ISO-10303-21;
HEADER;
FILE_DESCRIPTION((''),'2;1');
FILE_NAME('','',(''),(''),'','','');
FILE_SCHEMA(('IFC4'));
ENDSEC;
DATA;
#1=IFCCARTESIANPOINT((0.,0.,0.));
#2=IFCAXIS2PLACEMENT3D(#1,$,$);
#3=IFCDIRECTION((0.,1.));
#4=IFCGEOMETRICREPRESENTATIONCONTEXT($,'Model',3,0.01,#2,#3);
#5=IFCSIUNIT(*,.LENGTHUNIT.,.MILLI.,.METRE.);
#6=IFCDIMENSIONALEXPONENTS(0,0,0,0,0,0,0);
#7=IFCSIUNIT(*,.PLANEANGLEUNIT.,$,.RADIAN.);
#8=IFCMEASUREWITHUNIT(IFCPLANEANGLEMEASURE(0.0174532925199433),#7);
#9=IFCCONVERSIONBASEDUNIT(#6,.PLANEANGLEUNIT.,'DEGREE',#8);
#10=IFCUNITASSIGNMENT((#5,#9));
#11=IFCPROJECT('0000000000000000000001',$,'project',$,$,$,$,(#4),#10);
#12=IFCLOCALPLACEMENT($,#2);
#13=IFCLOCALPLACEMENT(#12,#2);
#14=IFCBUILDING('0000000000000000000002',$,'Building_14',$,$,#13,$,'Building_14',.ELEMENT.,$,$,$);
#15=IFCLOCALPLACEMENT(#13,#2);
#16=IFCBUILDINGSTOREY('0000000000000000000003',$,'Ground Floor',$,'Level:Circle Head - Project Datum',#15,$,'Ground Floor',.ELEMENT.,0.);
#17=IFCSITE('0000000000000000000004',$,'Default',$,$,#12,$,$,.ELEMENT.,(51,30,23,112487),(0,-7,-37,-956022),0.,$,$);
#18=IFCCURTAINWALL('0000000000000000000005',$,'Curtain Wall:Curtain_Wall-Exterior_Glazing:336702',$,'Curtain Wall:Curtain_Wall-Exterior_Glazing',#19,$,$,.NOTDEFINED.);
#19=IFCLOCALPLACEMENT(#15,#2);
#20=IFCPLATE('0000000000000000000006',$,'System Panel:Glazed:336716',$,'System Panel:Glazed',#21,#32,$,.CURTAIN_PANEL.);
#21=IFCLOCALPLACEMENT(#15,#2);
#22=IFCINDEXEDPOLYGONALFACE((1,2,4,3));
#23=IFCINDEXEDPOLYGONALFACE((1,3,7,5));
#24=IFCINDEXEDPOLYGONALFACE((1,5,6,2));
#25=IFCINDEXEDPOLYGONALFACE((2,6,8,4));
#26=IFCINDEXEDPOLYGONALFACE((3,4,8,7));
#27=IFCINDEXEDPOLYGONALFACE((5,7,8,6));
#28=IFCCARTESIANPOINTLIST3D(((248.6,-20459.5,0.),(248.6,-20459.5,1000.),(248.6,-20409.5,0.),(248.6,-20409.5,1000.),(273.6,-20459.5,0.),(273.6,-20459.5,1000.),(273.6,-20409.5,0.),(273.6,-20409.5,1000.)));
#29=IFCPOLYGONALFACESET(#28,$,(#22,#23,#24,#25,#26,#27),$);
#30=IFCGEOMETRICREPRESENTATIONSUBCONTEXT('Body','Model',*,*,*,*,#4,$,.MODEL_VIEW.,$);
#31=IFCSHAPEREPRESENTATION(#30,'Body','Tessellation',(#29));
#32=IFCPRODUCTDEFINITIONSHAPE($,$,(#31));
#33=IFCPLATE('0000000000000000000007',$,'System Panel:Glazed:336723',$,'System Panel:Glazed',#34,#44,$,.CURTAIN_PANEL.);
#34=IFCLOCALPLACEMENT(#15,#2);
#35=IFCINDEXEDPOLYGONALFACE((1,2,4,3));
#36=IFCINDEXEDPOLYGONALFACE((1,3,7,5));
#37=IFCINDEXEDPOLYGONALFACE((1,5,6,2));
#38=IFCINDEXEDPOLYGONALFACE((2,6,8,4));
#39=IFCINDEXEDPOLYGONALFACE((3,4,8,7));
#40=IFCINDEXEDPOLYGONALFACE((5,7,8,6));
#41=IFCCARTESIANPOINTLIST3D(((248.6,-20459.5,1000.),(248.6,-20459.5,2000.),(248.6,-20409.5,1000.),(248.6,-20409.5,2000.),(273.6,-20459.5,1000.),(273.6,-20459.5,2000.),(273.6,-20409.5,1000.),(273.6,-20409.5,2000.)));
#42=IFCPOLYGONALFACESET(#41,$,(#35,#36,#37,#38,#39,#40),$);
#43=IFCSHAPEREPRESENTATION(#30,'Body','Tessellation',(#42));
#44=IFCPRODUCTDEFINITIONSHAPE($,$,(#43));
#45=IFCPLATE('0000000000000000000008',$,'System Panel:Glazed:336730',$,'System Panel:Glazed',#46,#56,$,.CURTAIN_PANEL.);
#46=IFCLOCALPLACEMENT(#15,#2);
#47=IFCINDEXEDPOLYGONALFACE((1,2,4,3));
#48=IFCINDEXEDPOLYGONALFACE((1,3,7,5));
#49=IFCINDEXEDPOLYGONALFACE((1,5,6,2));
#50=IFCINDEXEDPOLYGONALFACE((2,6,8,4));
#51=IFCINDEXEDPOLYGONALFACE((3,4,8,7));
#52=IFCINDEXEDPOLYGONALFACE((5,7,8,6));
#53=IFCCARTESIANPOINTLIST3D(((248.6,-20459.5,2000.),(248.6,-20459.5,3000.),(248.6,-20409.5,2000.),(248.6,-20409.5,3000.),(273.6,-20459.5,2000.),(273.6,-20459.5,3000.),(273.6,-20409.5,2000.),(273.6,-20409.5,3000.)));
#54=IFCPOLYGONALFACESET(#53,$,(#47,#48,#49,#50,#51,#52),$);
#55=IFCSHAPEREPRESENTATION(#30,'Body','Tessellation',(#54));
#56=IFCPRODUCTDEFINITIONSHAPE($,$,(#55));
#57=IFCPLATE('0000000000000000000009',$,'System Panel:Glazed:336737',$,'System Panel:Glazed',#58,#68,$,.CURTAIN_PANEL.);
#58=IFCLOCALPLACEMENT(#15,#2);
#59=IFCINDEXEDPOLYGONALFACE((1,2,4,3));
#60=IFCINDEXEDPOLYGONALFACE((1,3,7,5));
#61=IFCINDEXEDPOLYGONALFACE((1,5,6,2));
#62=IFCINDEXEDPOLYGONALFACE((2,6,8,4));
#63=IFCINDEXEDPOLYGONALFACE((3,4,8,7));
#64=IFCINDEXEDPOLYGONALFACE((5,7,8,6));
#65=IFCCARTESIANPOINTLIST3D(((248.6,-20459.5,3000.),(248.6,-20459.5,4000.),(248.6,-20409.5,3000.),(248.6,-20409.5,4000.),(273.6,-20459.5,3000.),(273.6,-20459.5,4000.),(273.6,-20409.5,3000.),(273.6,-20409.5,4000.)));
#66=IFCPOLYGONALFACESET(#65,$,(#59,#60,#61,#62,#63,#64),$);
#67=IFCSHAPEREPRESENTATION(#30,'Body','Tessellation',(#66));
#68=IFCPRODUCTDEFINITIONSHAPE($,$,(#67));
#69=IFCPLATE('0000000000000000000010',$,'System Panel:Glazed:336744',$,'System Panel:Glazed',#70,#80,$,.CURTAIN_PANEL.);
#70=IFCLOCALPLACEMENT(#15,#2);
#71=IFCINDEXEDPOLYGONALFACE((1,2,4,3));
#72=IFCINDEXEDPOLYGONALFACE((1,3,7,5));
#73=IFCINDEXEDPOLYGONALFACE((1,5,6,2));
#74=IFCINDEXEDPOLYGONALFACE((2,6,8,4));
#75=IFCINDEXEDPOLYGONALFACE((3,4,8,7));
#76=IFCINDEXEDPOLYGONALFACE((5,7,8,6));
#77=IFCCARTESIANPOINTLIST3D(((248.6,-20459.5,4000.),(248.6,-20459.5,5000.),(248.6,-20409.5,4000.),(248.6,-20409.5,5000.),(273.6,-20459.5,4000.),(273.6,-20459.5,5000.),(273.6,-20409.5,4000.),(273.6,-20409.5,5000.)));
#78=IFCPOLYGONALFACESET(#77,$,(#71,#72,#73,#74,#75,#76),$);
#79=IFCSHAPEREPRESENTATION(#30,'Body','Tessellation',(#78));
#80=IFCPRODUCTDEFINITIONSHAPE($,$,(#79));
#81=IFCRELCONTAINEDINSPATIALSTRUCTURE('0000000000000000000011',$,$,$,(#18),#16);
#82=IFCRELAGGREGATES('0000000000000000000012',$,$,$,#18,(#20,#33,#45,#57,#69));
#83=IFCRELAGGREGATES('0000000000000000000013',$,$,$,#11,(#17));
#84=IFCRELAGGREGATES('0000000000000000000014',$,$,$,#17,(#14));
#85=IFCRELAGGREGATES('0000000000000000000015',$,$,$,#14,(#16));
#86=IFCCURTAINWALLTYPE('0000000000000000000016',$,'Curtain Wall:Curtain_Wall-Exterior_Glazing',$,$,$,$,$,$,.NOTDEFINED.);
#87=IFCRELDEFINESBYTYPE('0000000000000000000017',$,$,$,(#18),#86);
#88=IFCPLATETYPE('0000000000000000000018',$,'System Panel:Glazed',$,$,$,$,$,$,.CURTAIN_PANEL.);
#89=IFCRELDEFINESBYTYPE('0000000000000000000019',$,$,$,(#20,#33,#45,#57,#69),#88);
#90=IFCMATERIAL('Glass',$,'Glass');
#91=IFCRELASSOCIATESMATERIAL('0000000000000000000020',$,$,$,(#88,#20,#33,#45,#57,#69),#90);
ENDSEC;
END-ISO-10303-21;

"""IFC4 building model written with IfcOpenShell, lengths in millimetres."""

from ifc_helpers import new_model, entity, si_unit, converted_unit, direction, frame, origin, place, context, subcontext, project, spatial, indexed_curve, outline, extrude, source, transform, mapped, material, type_object, type_shapes, element, aggregate, save


model = new_model("IFC4")

# Units and contexts
model_context = context("Model", 3, precision=0.01, world=origin(), true_north=direction((0.0, 1.0)))
body_context = subcontext(model_context, "Body", "Model", "MODEL_VIEW")
ifc_project = project(units=[si_unit("LENGTHUNIT", "METRE", prefix="MILLI"), converted_unit("PLANEANGLEUNIT", "DEGREE", entity("IfcPlaneAngleMeasure", 0.0174532925199433), si_unit("PLANEANGLEUNIT", "RADIAN"), dimensions=[0, 0, 0, 0, 0, 0, 0])], contexts=[model_context])

# Site, building, storey
site_placement = place(None, origin())
site = spatial("IfcSite", under=ifc_project, at=site_placement, Name="Default", CompositionType="ELEMENT", RefLatitude=(51, 30, 23, 112487), RefLongitude=(0, -7, -37, -956022), RefElevation=0.0)
building_placement = place(site_placement, origin())
building = spatial("IfcBuilding", under=site, at=building_placement, Name="Building_14", LongName="Building_14", CompositionType="ELEMENT")
storey_placement = place(building_placement, origin())
storey = spatial("IfcBuildingStorey", under=building, at=storey_placement, Name="Ground Floor", ObjectType="Level:Circle Head - Project Datum", LongName="Ground Floor", CompositionType="ELEMENT", Elevation=0.0)

# Curtain wall
curtain_wall_type = type_object("IfcCurtainWallType", Name="Curtain Wall:Curtain_Wall-Exterior_Glazing", PredefinedType="NOTDEFINED")
curtain_wall_1_placement = place(storey_placement, origin())
curtain_wall_1 = element("IfcCurtainWall", 1, at=curtain_wall_1_placement, inside=storey, type_object=curtain_wall_type, Name="Curtain Wall:Curtain_Wall-Exterior_Glazing:336702", ObjectType="Curtain Wall:Curtain_Wall-Exterior_Glazing", PredefinedType="NOTDEFINED")
ifc_material = material(Name="Glass", Category="Glass")

# Plates
plate_type_1 = type_object("IfcPlateType", Name="System Panel:Glazed", PredefinedType="CURTAIN_PANEL", material=ifc_material)
shared_shape_1 = source(origin(), body_context, "Body", "SweptSolid", [
    extrude(outline(indexed_curve([(-12.5, -25.0), (12.5, -25.0), (12.5, 25.0), (-12.5, 25.0), (-12.5, -25.0)], self_intersect=False)), frame((0.0, -37.0, 0.0), z_axis=(0.0, 0.0, 1.0), x_axis=(0.0, 1.0, 0.0)), (0.0, 0.0, 1.0), 1000.0),
])
type_shapes(plate_type_1, [shared_shape_1])
plate_1_placement = place(curtain_wall_1_placement, frame((298.1, -20434.5, 0.0), z_axis=(0.0, 0.0, 1.0), x_axis=(0.0, -1.0, 0.0)))
plate_1 = element("IfcPlate", 2, at=plate_1_placement, type_object=plate_type_1, material=ifc_material, Name="System Panel:Glazed:336716", ObjectType="System Panel:Glazed", PredefinedType="CURTAIN_PANEL", context=body_context, shape_type="MappedRepresentation", body=[
    mapped(shared_shape_1, transform((0.0, 0.0, 0.0), scale=1.0)),
])
plate_2_placement = place(curtain_wall_1_placement, frame((298.1, -20434.5, 1000.0), z_axis=(0.0, 0.0, 1.0), x_axis=(0.0, -1.0, 0.0)))
plate_2 = element("IfcPlate", 3, at=plate_2_placement, type_object=plate_type_1, material=ifc_material, Name="System Panel:Glazed:336723", ObjectType="System Panel:Glazed", PredefinedType="CURTAIN_PANEL", context=body_context, shape_type="MappedRepresentation", body=[
    mapped(shared_shape_1, transform((0.0, 0.0, 0.0), scale=1.0)),
])
plate_3_placement = place(curtain_wall_1_placement, frame((298.1, -20434.5, 2000.0), z_axis=(0.0, 0.0, 1.0), x_axis=(0.0, -1.0, 0.0)))
plate_3 = element("IfcPlate", 4, at=plate_3_placement, type_object=plate_type_1, material=ifc_material, Name="System Panel:Glazed:336730", ObjectType="System Panel:Glazed", PredefinedType="CURTAIN_PANEL", context=body_context, shape_type="MappedRepresentation", body=[
    mapped(shared_shape_1, transform((0.0, 0.0, 0.0), scale=1.0)),
])
plate_4_placement = place(curtain_wall_1_placement, frame((298.1, -20434.5, 3000.0), z_axis=(0.0, 0.0, 1.0), x_axis=(0.0, -1.0, 0.0)))
plate_4 = element("IfcPlate", 5, at=plate_4_placement, type_object=plate_type_1, material=ifc_material, Name="System Panel:Glazed:336737", ObjectType="System Panel:Glazed", PredefinedType="CURTAIN_PANEL", context=body_context, shape_type="MappedRepresentation", body=[
    mapped(shared_shape_1, transform((0.0, 0.0, 0.0), scale=1.0)),
])
plate_5_placement = place(curtain_wall_1_placement, frame((298.1, -20434.5, 4000.0), z_axis=(0.0, 0.0, 1.0), x_axis=(0.0, -1.0, 0.0)))
plate_5 = element("IfcPlate", 6, at=plate_5_placement, type_object=plate_type_1, material=ifc_material, Name="System Panel:Glazed:336744", ObjectType="System Panel:Glazed", PredefinedType="CURTAIN_PANEL", context=body_context, shape_type="MappedRepresentation", body=[
    mapped(shared_shape_1, transform((0.0, 0.0, 0.0), scale=1.0)),
])
aggregate(curtain_wall_1, [plate_1, plate_2, plate_3, plate_4, plate_5])

save(model, "model.ifc")
